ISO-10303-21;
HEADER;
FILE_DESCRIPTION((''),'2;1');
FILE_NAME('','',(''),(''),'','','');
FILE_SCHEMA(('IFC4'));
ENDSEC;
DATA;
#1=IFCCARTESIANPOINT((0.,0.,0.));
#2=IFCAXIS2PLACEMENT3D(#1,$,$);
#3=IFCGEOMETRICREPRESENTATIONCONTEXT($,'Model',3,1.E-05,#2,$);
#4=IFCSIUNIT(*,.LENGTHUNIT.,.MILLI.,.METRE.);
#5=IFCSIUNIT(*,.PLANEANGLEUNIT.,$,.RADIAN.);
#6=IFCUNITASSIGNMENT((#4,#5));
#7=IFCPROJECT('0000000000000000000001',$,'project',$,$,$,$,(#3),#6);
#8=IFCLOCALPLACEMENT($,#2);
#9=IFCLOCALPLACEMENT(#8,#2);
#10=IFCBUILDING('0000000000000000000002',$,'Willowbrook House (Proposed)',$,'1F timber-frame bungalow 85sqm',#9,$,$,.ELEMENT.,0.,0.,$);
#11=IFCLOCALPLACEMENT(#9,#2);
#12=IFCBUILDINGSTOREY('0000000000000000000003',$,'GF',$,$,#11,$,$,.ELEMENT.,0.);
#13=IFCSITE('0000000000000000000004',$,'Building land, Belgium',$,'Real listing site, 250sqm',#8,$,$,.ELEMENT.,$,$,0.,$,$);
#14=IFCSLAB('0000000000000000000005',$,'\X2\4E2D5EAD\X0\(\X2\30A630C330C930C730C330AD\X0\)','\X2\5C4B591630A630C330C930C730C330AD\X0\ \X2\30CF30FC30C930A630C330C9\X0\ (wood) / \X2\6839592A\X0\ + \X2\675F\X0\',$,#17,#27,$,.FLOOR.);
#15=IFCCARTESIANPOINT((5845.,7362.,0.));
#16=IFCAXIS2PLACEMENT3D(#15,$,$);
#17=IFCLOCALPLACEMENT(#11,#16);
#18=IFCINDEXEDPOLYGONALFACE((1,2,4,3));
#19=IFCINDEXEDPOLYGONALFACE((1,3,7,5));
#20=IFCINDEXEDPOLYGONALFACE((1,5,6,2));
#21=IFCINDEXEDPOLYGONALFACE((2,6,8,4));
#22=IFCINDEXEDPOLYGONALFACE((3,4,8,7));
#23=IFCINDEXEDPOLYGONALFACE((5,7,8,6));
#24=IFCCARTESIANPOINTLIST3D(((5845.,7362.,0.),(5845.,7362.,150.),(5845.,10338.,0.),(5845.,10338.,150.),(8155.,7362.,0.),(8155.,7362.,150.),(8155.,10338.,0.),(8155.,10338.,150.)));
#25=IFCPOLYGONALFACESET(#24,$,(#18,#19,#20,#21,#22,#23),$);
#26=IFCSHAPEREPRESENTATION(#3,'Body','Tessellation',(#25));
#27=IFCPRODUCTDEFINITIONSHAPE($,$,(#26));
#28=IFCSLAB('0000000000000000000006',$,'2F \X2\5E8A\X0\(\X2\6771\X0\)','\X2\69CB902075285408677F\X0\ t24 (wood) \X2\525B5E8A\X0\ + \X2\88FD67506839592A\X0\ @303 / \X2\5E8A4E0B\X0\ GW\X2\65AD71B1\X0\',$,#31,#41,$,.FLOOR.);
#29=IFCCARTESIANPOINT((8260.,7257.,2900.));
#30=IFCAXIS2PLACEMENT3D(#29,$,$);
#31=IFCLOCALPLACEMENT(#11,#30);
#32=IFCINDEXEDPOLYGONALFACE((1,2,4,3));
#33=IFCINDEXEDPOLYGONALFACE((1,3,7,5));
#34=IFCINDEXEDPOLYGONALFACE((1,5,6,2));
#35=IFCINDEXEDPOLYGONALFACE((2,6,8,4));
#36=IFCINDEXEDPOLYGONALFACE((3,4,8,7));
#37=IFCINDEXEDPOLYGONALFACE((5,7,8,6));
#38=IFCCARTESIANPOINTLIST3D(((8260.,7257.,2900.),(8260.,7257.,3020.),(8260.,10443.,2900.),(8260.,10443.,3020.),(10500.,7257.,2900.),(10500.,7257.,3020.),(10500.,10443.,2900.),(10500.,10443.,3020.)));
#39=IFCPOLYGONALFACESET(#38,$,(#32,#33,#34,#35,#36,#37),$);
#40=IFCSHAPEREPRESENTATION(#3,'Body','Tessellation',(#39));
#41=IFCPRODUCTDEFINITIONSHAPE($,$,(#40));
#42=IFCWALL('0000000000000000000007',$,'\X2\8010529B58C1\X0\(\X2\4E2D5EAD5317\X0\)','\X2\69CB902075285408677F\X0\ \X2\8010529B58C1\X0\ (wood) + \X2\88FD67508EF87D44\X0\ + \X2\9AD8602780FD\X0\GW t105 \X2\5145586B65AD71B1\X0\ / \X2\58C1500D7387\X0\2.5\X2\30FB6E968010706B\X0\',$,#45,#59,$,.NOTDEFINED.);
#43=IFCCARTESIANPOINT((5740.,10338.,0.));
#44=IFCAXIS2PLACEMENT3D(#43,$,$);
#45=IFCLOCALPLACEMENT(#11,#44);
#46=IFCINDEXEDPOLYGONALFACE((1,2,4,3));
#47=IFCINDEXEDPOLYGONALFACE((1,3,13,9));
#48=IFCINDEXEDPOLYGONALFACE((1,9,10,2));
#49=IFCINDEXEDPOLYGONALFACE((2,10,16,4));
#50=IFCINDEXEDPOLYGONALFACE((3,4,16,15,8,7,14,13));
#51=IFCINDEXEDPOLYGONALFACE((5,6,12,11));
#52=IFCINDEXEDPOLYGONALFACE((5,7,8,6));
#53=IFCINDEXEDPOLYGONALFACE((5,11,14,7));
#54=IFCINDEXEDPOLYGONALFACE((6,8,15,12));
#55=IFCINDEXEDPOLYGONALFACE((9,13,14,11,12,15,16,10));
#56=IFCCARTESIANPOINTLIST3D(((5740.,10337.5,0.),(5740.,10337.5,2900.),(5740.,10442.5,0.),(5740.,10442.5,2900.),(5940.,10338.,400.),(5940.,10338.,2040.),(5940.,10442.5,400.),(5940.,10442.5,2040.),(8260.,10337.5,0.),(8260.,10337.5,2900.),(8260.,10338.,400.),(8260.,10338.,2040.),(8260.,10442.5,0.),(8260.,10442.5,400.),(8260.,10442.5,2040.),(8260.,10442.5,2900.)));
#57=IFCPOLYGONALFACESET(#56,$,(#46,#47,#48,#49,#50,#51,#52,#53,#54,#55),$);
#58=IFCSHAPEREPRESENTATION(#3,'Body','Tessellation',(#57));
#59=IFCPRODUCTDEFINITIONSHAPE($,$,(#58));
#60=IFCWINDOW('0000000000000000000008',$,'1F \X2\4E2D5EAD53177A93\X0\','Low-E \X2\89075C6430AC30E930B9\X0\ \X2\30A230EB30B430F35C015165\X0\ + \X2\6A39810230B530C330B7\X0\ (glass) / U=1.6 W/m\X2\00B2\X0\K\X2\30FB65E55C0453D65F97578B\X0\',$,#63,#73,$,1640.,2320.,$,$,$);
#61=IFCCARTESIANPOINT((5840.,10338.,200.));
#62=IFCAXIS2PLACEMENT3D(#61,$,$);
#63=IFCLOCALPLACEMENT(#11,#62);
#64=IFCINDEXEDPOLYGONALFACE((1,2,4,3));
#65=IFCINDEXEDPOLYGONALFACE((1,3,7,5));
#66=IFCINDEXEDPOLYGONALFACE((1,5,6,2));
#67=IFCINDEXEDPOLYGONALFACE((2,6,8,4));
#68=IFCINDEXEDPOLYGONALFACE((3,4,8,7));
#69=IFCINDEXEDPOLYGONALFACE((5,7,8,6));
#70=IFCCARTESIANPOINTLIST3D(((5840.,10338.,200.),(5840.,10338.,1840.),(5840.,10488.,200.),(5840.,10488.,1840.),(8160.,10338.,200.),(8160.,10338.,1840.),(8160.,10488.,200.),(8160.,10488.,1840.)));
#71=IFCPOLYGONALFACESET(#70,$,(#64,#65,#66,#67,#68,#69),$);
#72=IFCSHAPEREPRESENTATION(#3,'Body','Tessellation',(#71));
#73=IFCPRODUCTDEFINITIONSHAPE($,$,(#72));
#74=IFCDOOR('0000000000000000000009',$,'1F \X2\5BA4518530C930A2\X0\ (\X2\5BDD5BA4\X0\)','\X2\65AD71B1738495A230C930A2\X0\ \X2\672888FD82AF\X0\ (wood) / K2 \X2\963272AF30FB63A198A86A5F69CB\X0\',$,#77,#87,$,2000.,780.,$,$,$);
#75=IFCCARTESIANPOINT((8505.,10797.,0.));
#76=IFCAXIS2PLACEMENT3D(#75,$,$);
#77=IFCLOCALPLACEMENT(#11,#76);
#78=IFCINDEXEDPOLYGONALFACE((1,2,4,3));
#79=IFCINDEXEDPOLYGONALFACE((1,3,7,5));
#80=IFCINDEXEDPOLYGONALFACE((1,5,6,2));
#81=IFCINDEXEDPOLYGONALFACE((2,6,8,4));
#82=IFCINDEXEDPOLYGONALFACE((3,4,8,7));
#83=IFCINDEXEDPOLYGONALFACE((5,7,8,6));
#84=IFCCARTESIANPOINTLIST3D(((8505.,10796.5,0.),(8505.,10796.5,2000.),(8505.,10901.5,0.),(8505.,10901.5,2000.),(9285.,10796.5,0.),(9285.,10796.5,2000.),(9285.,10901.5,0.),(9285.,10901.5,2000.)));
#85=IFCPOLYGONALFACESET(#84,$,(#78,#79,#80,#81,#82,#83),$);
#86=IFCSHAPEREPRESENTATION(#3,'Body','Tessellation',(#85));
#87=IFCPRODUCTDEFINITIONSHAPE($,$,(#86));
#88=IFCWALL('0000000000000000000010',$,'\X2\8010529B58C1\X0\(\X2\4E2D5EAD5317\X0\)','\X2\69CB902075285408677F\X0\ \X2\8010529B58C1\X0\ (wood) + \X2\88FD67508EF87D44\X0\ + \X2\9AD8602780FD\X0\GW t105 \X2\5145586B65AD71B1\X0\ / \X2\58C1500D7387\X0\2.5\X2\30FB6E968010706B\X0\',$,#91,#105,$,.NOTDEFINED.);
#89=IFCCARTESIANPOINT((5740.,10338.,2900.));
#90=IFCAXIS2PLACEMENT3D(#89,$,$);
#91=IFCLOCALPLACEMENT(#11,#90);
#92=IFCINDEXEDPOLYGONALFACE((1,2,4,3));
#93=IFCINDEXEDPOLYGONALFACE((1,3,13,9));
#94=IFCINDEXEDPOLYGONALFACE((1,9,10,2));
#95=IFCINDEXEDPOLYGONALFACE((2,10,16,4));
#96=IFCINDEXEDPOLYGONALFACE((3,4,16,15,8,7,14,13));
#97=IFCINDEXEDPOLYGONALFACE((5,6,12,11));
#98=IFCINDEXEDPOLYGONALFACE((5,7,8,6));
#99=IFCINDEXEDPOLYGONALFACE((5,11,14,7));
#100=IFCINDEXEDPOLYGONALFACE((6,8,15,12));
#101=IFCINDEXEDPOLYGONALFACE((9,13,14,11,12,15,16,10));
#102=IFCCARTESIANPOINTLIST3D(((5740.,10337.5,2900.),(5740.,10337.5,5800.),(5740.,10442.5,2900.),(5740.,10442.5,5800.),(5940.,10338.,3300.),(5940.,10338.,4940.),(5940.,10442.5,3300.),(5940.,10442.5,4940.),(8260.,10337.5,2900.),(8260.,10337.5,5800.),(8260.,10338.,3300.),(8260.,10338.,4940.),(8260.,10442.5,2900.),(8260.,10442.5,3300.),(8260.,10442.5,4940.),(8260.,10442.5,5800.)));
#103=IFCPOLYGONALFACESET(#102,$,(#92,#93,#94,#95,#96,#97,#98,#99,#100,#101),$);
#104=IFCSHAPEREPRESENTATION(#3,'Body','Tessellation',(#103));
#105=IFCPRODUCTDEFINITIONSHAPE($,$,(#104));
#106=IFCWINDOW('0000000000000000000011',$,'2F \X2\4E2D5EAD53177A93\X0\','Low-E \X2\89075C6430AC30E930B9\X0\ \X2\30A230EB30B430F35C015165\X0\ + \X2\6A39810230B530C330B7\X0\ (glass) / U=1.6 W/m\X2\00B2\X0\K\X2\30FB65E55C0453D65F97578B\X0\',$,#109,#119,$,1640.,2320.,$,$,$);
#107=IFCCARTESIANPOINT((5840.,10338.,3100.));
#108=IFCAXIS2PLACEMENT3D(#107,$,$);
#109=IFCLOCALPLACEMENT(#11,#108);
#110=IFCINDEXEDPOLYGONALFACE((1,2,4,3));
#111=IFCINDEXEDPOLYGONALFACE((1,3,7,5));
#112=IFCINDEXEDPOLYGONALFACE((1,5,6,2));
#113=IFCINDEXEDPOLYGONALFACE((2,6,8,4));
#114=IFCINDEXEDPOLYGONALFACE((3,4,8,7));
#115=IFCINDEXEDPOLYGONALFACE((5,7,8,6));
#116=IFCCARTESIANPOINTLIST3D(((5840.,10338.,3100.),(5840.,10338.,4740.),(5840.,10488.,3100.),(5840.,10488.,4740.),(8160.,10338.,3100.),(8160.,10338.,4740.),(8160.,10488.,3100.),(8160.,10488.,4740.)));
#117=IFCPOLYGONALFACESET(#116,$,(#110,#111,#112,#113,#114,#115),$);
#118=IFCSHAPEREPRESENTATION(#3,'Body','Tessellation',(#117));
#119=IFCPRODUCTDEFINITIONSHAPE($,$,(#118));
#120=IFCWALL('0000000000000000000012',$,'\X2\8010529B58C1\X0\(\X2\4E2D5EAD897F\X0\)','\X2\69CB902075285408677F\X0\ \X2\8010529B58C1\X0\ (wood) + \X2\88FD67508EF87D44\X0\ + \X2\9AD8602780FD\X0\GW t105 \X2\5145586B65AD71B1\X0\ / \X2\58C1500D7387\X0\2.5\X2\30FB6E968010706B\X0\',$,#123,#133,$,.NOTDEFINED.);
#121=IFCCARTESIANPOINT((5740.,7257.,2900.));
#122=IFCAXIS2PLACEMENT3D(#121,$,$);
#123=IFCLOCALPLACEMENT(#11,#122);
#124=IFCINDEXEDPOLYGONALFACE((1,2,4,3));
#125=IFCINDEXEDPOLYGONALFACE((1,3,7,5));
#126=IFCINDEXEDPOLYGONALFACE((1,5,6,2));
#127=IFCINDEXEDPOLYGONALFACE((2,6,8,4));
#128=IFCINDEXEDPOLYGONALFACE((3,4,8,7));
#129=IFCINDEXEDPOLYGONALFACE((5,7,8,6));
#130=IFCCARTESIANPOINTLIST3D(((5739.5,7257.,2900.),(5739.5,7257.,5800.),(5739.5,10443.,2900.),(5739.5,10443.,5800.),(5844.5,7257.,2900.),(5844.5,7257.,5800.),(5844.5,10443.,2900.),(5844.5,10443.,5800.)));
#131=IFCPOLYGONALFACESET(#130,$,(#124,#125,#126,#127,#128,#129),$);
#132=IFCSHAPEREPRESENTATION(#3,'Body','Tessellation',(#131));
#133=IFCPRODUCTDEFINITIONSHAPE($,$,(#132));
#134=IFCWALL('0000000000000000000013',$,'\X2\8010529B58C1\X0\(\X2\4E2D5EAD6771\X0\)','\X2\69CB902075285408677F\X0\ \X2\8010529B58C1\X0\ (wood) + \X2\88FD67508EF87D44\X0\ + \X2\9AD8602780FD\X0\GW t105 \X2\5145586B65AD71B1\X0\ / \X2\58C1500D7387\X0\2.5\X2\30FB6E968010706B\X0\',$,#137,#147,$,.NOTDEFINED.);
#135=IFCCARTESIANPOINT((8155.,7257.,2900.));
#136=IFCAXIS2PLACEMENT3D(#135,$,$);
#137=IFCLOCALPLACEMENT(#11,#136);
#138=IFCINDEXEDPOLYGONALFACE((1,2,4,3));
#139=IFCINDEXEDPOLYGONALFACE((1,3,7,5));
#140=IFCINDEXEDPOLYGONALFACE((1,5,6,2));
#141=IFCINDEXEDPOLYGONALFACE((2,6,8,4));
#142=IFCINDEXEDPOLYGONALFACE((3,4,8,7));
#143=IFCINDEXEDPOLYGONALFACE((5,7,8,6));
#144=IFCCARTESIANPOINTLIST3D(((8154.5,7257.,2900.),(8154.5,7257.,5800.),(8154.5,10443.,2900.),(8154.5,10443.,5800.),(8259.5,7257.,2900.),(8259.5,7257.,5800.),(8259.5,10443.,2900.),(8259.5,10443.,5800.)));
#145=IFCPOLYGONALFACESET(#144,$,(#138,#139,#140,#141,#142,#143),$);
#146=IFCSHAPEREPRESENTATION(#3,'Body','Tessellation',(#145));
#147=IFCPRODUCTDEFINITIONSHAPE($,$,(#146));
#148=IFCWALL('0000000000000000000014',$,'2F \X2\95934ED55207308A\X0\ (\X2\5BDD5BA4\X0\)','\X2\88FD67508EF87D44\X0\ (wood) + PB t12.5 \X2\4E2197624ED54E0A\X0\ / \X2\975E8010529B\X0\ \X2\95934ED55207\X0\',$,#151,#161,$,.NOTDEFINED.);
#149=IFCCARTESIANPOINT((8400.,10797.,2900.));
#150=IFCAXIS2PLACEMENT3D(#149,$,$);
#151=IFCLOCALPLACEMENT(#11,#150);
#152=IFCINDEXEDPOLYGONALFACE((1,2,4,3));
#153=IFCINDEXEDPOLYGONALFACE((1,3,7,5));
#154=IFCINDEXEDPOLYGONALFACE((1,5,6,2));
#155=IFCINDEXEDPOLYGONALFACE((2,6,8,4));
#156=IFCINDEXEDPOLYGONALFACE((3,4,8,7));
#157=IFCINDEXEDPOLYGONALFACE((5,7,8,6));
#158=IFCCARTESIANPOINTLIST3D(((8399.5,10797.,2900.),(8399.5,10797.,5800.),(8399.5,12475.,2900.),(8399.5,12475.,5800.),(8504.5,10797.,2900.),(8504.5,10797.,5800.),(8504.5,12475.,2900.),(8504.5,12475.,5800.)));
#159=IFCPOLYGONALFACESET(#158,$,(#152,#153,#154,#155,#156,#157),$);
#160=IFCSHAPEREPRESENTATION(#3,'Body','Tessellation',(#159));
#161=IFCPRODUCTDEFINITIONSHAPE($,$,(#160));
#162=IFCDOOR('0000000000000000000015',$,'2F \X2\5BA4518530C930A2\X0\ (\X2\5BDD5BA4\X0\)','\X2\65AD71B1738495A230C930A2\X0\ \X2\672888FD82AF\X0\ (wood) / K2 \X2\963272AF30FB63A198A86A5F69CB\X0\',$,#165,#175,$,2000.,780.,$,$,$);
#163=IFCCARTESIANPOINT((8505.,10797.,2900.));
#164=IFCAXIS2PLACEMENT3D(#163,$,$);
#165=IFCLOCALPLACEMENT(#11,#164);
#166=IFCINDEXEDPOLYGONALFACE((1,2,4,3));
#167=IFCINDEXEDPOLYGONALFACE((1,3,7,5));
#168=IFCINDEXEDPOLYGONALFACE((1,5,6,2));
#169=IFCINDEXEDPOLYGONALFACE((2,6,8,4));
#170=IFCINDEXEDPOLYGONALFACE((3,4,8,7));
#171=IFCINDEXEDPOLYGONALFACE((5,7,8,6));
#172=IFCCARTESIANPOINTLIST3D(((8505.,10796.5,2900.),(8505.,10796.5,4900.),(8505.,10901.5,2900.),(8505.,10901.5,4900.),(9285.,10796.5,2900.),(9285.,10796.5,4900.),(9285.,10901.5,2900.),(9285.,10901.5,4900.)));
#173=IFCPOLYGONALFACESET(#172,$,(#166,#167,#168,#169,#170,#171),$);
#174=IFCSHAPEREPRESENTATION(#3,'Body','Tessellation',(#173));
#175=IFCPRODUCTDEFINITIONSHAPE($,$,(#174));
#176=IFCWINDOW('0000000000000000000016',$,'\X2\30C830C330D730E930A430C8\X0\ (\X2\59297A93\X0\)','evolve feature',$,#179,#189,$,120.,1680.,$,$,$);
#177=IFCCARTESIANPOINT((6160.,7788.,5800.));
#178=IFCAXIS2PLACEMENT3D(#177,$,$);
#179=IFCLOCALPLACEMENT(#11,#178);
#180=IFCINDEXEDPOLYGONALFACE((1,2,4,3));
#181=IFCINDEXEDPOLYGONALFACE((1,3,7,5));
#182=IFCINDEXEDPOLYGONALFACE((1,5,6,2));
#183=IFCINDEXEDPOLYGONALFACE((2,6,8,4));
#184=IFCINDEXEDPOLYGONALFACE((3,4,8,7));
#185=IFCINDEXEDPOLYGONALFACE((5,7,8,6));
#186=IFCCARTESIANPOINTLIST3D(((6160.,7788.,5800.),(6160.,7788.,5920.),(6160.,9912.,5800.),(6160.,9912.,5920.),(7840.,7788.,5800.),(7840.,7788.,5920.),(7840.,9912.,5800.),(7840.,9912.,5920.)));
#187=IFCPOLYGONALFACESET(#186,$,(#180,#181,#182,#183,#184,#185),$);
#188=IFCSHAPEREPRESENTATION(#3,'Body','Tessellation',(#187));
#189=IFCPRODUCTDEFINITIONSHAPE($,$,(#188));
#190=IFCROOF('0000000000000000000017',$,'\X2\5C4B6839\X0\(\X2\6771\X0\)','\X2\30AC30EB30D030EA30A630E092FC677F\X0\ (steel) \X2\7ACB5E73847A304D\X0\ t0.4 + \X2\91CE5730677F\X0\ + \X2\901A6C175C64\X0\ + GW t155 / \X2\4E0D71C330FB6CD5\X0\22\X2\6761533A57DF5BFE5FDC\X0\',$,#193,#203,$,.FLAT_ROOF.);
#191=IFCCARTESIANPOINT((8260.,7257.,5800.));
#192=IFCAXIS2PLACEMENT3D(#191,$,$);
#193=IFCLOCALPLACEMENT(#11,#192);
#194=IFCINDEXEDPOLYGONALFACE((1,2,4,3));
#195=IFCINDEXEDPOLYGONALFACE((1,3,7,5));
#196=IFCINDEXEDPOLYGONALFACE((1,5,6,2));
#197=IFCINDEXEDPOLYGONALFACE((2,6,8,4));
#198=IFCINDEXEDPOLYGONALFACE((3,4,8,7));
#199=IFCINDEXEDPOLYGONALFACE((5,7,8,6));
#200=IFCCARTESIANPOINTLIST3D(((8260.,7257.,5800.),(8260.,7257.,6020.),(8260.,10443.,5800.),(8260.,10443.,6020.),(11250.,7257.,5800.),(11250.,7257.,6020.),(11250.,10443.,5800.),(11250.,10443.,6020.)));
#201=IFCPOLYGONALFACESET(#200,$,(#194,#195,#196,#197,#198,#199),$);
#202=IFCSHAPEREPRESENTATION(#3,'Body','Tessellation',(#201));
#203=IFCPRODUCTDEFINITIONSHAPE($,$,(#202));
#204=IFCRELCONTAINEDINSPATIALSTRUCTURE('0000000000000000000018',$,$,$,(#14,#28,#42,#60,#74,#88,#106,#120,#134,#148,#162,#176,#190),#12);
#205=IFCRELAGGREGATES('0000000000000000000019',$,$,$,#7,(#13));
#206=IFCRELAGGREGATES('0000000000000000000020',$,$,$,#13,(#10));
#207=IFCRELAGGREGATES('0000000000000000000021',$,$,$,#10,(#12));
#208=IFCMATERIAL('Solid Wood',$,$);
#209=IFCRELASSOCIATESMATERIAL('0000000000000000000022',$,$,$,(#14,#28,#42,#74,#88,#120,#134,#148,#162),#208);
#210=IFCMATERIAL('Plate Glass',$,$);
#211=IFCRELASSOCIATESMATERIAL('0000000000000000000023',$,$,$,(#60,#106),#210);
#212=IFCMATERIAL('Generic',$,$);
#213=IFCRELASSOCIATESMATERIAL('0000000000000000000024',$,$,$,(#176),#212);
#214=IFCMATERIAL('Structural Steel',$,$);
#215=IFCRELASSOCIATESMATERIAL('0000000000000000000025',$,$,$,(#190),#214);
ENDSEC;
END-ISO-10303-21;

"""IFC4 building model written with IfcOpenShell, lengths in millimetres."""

from ifc_helpers import new_model, si_unit, frame, frame_2d, origin, place, context, project, spatial, rectangle, extrude, material, element, fill, save


model = new_model("IFC4")

# Units and contexts
model_context = context("Model", 3, precision=1e-05, world=origin())
ifc_project = project(units=[si_unit("LENGTHUNIT", "METRE", prefix="MILLI"), si_unit("PLANEANGLEUNIT", "RADIAN")], contexts=[model_context])

# Site, building, storey
site_placement = place(None, origin())
site = spatial("IfcSite", under=ifc_project, at=site_placement, Name="Building land, Belgium", ObjectType="Real listing site, 250sqm", CompositionType="ELEMENT", RefElevation=0.0)
building_placement = place(site_placement, origin())
building = spatial("IfcBuilding", under=site, at=building_placement, Name="Willowbrook House (Proposed)", ObjectType="1F timber-frame bungalow 85sqm", CompositionType="ELEMENT", ElevationOfRefHeight=0.0, ElevationOfTerrain=0.0)
storey_placement = place(building_placement, origin())
storey = spatial("IfcBuildingStorey", under=building, at=storey_placement, Name="GF", CompositionType="ELEMENT", Elevation=0.0)

# Slabs
ifc_material_1 = material(Name="Solid Wood")
slab_1_placement = place(storey_placement, frame((5845.0, 7362.0, 0.0)))
element("IfcSlab", 1, at=slab_1_placement, inside=storey, material=ifc_material_1, Name="中庭(ウッドデッキ)", Description="屋外ウッドデッキ ハードウッド (wood) / 根太 + 束", PredefinedType="FLOOR", context=model_context, shape_type="SweptSolid", body=[
    extrude(rectangle(XDim=2310.0, YDim=2976.0, at=frame_2d((1155.0, 1488.0))), frame((5845.0, 7362.0, 0.0)), (0.0, 0.0, 1.0), 150.0),
])
slab_2_placement = place(storey_placement, frame((8260.0, 7257.0, 2900.0)))
element("IfcSlab", 2, at=slab_2_placement, inside=storey, material=ifc_material_1, Name="2F 床(東)", Description="構造用合板 t24 (wood) 剛床 + 製材根太 @303 / 床下 GW断熱", PredefinedType="FLOOR", context=model_context, shape_type="SweptSolid", body=[
    extrude(rectangle(XDim=2240.0, YDim=3186.0, at=frame_2d((1120.0, 1593.0))), frame((8260.0, 7257.0, 2900.0)), (0.0, 0.0, 1.0), 120.0),
])

# Wall, opening, window
wall_1_placement = place(storey_placement, frame((5740.0, 10338.0, 0.0)))
wall_1 = element("IfcWall", 3, at=wall_1_placement, inside=storey, material=ifc_material_1, Name="耐力壁(中庭北)", Description="構造用合板 耐力壁 (wood) + 製材軸組 + 高性能GW t105 充填断熱 / 壁倍率2.5・準耐火", PredefinedType="NOTDEFINED", context=model_context, shape_type="SweptSolid", body=[
    extrude(rectangle(XDim=2520.0, YDim=105.0, at=frame_2d((1260.0, 52.0))), frame((5740.0, 10338.0, 0.0)), (0.0, 0.0, 1.0), 2900.0),
])
opening_1_placement = place(storey_placement, frame((5840.0, 10338.0, 200.0)))
opening_1 = element("IfcOpeningElement", 4, at=opening_1_placement, cuts=wall_1, PredefinedType="NOTDEFINED", context=model_context, shape_type="SweptSolid", body=[
    extrude(rectangle(XDim=2320.0, YDim=150.0, at=frame_2d((1160.0, 75.0))), frame((5840.0, 10338.0, 200.0)), (0.0, 0.0, 1.0), 1640.0),
])
ifc_material_2 = material(Name="Plate Glass")
window_1_placement = place(storey_placement, frame((5840.0, 10338.0, 200.0)))
window_1 = element("IfcWindow", 5, at=window_1_placement, inside=storey, material=ifc_material_2, Name="1F 中庭北窓", Description="Low-E 複層ガラス アルゴン封入 + 樹脂サッシ (glass) / U=1.6 W/m²K・日射取得型", OverallHeight=1640.0, OverallWidth=2320.0, context=model_context, shape_type="SweptSolid", body=[
    extrude(rectangle(XDim=2320.0, YDim=150.0, at=frame_2d((1160.0, 75.0))), frame((5840.0, 10338.0, 200.0)), (0.0, 0.0, 1.0), 1640.0),
])
fill(opening_1, window_1)

# Door
door_1_placement = place(storey_placement, frame((8505.0, 10797.0, 0.0)))
element("IfcDoor", 6, at=door_1_placement, inside=storey, material=ifc_material_1, Name="1F 室内ドア (寝室)", Description="断熱玄関ドア 木製芯 (wood) / K2 防犯・採風機構", OverallHeight=2000.0, OverallWidth=780.0, context=model_context, shape_type="SweptSolid", body=[
    extrude(rectangle(XDim=780.0, YDim=105.0, at=frame_2d((390.0, 52.0))), frame((8505.0, 10797.0, 0.0)), (0.0, 0.0, 1.0), 2000.0),
])

# Wall, opening, window
wall_2_placement = place(storey_placement, frame((5740.0, 10338.0, 2900.0)))
wall_2 = element("IfcWall", 7, at=wall_2_placement, inside=storey, material=ifc_material_1, Name="耐力壁(中庭北)", Description="構造用合板 耐力壁 (wood) + 製材軸組 + 高性能GW t105 充填断熱 / 壁倍率2.5・準耐火", PredefinedType="NOTDEFINED", context=model_context, shape_type="SweptSolid", body=[
    extrude(rectangle(XDim=2520.0, YDim=105.0, at=frame_2d((1260.0, 52.0))), frame((5740.0, 10338.0, 2900.0)), (0.0, 0.0, 1.0), 2900.0),
])
opening_2_placement = place(storey_placement, frame((5840.0, 10338.0, 3100.0)))
opening_2 = element("IfcOpeningElement", 8, at=opening_2_placement, cuts=wall_2, PredefinedType="NOTDEFINED", context=model_context, shape_type="SweptSolid", body=[
    extrude(rectangle(XDim=2320.0, YDim=150.0, at=frame_2d((1160.0, 75.0))), frame((5840.0, 10338.0, 3100.0)), (0.0, 0.0, 1.0), 1640.0),
])
window_2_placement = place(storey_placement, frame((5840.0, 10338.0, 3100.0)))
window_2 = element("IfcWindow", 9, at=window_2_placement, inside=storey, material=ifc_material_2, Name="2F 中庭北窓", Description="Low-E 複層ガラス アルゴン封入 + 樹脂サッシ (glass) / U=1.6 W/m²K・日射取得型", OverallHeight=1640.0, OverallWidth=2320.0, context=model_context, shape_type="SweptSolid", body=[
    extrude(rectangle(XDim=2320.0, YDim=150.0, at=frame_2d((1160.0, 75.0))), frame((5840.0, 10338.0, 3100.0)), (0.0, 0.0, 1.0), 1640.0),
])
fill(opening_2, window_2)

# Walls
wall_3_placement = place(storey_placement, frame((5740.0, 7257.0, 2900.0)))
element("IfcWall", 10, at=wall_3_placement, inside=storey, material=ifc_material_1, Name="耐力壁(中庭西)", Description="構造用合板 耐力壁 (wood) + 製材軸組 + 高性能GW t105 充填断熱 / 壁倍率2.5・準耐火", PredefinedType="NOTDEFINED", context=model_context, shape_type="SweptSolid", body=[
    extrude(rectangle(XDim=105.0, YDim=3186.0, at=frame_2d((52.0, 1593.0))), frame((5740.0, 7257.0, 2900.0)), (0.0, 0.0, 1.0), 2900.0),
])
wall_4_placement = place(storey_placement, frame((8155.0, 7257.0, 2900.0)))
element("IfcWall", 11, at=wall_4_placement, inside=storey, material=ifc_material_1, Name="耐力壁(中庭東)", Description="構造用合板 耐力壁 (wood) + 製材軸組 + 高性能GW t105 充填断熱 / 壁倍率2.5・準耐火", PredefinedType="NOTDEFINED", context=model_context, shape_type="SweptSolid", body=[
    extrude(rectangle(XDim=105.0, YDim=3186.0, at=frame_2d((52.0, 1593.0))), frame((8155.0, 7257.0, 2900.0)), (0.0, 0.0, 1.0), 2900.0),
])
wall_5_placement = place(storey_placement, frame((8400.0, 10797.0, 2900.0)))
element("IfcWall", 12, at=wall_5_placement, inside=storey, material=ifc_material_1, Name="2F 間仕切り (寝室)", Description="製材軸組 (wood) + PB t12.5 両面仕上 / 非耐力 間仕切", PredefinedType="NOTDEFINED", context=model_context, shape_type="SweptSolid", body=[
    extrude(rectangle(XDim=105.0, YDim=1678.0, at=frame_2d((52.0, 839.0))), frame((8400.0, 10797.0, 2900.0)), (0.0, 0.0, 1.0), 2900.0),
])

# Door
door_2_placement = place(storey_placement, frame((8505.0, 10797.0, 2900.0)))
element("IfcDoor", 13, at=door_2_placement, inside=storey, material=ifc_material_1, Name="2F 室内ドア (寝室)", Description="断熱玄関ドア 木製芯 (wood) / K2 防犯・採風機構", OverallHeight=2000.0, OverallWidth=780.0, context=model_context, shape_type="SweptSolid", body=[
    extrude(rectangle(XDim=780.0, YDim=105.0, at=frame_2d((390.0, 52.0))), frame((8505.0, 10797.0, 2900.0)), (0.0, 0.0, 1.0), 2000.0),
])

# Window
ifc_material_3 = material(Name="Generic")
window_3_placement = place(storey_placement, frame((6160.0, 7788.0, 5800.0)))
element("IfcWindow", 14, at=window_3_placement, inside=storey, material=ifc_material_3, Name="トップライト (天窓)", Description="evolve feature", OverallHeight=120.0, OverallWidth=1680.0, context=model_context, shape_type="SweptSolid", body=[
    extrude(rectangle(XDim=1680.0, YDim=2124.0, at=frame_2d((840.0, 1062.0))), frame((6160.0, 7788.0, 5800.0)), (0.0, 0.0, 1.0), 120.0),
])

# Roof
ifc_material_4 = material(Name="Structural Steel")
roof_placement = place(storey_placement, frame((8260.0, 7257.0, 5800.0)))
element("IfcRoof", 15, at=roof_placement, inside=storey, material=ifc_material_4, Name="屋根(東)", Description="ガルバリウム鋼板 (steel) 立平葺き t0.4 + 野地板 + 通気層 + GW t155 / 不燃・法22条区域対応", PredefinedType="FLAT_ROOF", context=model_context, shape_type="SweptSolid", body=[
    extrude(rectangle(XDim=2990.0, YDim=3186.0, at=frame_2d((1495.0, 1593.0))), frame((8260.0, 7257.0, 5800.0)), (0.0, 0.0, 1.0), 220.0),
])

save(model, "model.ifc")
